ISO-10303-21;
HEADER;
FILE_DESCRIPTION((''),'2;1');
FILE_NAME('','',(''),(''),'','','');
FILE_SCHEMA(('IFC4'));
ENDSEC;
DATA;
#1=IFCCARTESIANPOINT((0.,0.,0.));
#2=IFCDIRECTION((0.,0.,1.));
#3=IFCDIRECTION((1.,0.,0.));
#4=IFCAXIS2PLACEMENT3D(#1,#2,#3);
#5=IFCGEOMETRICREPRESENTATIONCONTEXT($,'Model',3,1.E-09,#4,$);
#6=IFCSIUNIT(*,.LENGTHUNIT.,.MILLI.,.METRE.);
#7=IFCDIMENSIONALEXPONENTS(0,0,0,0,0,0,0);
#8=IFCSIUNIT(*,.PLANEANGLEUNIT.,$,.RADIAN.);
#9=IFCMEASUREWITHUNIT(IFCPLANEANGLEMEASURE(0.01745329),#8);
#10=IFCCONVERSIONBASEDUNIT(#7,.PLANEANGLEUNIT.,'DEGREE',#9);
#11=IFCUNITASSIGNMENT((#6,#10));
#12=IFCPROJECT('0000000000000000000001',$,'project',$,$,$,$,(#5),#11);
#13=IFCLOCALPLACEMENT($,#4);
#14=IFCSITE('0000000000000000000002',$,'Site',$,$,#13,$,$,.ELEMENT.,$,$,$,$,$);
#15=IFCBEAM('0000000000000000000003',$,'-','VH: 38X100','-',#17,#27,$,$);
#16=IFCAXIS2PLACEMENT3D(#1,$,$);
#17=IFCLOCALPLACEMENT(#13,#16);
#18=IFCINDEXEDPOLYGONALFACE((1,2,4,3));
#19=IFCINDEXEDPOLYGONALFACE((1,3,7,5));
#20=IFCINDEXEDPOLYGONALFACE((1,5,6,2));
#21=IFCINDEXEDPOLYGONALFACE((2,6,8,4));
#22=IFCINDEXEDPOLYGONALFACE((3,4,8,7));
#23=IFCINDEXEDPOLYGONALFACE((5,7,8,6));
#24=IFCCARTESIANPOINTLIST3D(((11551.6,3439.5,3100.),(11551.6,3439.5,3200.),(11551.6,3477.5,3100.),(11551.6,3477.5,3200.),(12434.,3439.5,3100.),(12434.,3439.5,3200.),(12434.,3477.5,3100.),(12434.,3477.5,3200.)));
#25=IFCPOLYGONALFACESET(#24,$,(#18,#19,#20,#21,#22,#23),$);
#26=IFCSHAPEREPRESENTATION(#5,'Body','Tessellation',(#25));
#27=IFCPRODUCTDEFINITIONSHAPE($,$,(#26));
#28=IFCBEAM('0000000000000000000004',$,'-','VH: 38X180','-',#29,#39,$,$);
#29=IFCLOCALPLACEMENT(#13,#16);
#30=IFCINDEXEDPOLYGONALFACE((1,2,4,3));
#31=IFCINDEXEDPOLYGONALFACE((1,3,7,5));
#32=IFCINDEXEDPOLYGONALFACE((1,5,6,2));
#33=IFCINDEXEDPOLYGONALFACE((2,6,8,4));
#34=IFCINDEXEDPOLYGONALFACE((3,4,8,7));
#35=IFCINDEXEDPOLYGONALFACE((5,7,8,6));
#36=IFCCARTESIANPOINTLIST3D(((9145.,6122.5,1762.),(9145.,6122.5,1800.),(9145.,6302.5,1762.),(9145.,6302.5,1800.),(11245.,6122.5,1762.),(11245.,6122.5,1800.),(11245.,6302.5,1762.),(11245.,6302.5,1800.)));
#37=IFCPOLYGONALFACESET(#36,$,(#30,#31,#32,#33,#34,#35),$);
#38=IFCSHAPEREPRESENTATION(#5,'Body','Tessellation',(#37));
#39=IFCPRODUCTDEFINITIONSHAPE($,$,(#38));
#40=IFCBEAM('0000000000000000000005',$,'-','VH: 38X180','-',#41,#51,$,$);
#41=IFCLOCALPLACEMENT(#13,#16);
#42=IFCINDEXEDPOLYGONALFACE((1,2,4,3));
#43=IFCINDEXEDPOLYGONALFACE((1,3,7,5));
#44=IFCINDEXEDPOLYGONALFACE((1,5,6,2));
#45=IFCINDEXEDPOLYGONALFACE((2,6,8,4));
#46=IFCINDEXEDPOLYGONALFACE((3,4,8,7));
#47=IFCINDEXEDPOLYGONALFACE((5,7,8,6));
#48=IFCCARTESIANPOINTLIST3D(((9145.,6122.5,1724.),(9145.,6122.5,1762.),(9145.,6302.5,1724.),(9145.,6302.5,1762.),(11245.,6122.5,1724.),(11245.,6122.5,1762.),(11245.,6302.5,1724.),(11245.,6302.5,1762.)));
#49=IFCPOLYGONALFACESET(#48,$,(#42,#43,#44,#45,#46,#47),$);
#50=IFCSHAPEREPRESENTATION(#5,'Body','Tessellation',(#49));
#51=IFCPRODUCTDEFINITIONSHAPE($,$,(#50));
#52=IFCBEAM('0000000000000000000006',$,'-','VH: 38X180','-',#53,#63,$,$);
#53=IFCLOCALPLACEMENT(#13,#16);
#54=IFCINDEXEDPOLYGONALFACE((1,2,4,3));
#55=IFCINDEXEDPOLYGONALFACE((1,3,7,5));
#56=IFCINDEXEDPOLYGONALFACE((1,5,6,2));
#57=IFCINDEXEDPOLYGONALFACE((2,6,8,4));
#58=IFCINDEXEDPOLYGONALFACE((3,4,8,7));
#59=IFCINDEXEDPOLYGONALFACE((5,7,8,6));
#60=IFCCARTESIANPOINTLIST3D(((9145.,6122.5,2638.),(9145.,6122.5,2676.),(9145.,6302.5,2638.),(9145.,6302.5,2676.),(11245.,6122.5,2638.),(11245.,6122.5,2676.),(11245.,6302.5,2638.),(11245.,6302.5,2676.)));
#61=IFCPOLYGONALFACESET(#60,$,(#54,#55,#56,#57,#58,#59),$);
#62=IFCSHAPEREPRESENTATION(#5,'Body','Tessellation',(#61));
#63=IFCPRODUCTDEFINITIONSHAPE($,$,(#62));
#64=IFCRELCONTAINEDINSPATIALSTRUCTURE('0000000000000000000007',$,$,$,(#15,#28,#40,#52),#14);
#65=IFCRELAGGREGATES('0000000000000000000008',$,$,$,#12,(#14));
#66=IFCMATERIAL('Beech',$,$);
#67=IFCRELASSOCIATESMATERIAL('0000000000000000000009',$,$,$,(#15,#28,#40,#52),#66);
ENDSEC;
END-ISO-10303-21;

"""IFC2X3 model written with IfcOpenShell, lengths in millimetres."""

from ifc_helpers import new_model, entity, si_unit, converted_unit, frame, origin, origin_with_axes, origin_2d, place, context, project, spatial, rectangle, extrude, material, element, save


model = new_model("IFC2X3")

# Units and contexts
model_context = context("Model", 3, precision=1e-09, world=origin_with_axes())
ifc_project = project(units=[si_unit("LENGTHUNIT", "METRE", prefix="MILLI"), converted_unit("PLANEANGLEUNIT", "DEGREE", entity("IfcPlaneAngleMeasure", 0.01745329), si_unit("PLANEANGLEUNIT", "RADIAN"), dimensions=[0, 0, 0, 0, 0, 0, 0])], contexts=[model_context])

# Site
site_placement = place(None, origin_with_axes())
site = spatial("IfcSite", under=ifc_project, at=site_placement, Name="Site", CompositionType="ELEMENT")

# Shared definitions
ifc_material = material(Name="Beech")

# Beams
beam_1_placement = place(None, frame((11551.6, 3458.5, 3150.0), z_axis=(1.0, 0.000018, 0.0), x_axis=(-0.000018, 1.0, 0.0)))
element("IfcBeam", 1, at=beam_1_placement, inside=site, material=ifc_material, Name="-", Description="VH: 38X100", ObjectType="-", context=model_context, shape_type="SweptSolid", body=[
    extrude(rectangle(XDim=38.0, YDim=100.0, at=origin_2d()), origin(), (0.0, 0.0, 1.0), 882.4),
])
beam_2_placement = place(None, frame((11245.0, 6212.5, 1781.0), z_axis=(1.0, 0.0, 0.0), x_axis=(0.0, 0.0, -1.0)))
element("IfcBeam", 2, at=beam_2_placement, inside=site, material=ifc_material, Name="-", Description="VH: 38X180", ObjectType="-", context=model_context, shape_type="SweptSolid", body=[
    extrude(rectangle(XDim=38.0, YDim=180.0, at=origin_2d()), origin(), (0.0, 0.0, -1.0), 2100.0),
])
for number, where, z_axis, x_axis, name in (
    (3, (11245.0, 6212.5, 1743.0), (1.0, 0.0, 0.0), (0.0, 0.0, -1.0), "-"),
    (4, (11245.0, 6212.5, 2657.0), (1.0, 0.0, 0.0), (0.0, 0.0, -1.0), "-"),
):
    element("IfcBeam", number, at=place(None, frame(where, z_axis=z_axis, x_axis=x_axis)), inside=site, material=ifc_material, Name=name, Description="VH: 38X180", ObjectType="-", context=model_context, shape_type="SweptSolid", body=[
        extrude(rectangle(XDim=38.0, YDim=180.0, at=origin_2d()), origin(), (0.0, 0.0, -1.0), 2100.0),
    ])

save(model, "model.ifc")
